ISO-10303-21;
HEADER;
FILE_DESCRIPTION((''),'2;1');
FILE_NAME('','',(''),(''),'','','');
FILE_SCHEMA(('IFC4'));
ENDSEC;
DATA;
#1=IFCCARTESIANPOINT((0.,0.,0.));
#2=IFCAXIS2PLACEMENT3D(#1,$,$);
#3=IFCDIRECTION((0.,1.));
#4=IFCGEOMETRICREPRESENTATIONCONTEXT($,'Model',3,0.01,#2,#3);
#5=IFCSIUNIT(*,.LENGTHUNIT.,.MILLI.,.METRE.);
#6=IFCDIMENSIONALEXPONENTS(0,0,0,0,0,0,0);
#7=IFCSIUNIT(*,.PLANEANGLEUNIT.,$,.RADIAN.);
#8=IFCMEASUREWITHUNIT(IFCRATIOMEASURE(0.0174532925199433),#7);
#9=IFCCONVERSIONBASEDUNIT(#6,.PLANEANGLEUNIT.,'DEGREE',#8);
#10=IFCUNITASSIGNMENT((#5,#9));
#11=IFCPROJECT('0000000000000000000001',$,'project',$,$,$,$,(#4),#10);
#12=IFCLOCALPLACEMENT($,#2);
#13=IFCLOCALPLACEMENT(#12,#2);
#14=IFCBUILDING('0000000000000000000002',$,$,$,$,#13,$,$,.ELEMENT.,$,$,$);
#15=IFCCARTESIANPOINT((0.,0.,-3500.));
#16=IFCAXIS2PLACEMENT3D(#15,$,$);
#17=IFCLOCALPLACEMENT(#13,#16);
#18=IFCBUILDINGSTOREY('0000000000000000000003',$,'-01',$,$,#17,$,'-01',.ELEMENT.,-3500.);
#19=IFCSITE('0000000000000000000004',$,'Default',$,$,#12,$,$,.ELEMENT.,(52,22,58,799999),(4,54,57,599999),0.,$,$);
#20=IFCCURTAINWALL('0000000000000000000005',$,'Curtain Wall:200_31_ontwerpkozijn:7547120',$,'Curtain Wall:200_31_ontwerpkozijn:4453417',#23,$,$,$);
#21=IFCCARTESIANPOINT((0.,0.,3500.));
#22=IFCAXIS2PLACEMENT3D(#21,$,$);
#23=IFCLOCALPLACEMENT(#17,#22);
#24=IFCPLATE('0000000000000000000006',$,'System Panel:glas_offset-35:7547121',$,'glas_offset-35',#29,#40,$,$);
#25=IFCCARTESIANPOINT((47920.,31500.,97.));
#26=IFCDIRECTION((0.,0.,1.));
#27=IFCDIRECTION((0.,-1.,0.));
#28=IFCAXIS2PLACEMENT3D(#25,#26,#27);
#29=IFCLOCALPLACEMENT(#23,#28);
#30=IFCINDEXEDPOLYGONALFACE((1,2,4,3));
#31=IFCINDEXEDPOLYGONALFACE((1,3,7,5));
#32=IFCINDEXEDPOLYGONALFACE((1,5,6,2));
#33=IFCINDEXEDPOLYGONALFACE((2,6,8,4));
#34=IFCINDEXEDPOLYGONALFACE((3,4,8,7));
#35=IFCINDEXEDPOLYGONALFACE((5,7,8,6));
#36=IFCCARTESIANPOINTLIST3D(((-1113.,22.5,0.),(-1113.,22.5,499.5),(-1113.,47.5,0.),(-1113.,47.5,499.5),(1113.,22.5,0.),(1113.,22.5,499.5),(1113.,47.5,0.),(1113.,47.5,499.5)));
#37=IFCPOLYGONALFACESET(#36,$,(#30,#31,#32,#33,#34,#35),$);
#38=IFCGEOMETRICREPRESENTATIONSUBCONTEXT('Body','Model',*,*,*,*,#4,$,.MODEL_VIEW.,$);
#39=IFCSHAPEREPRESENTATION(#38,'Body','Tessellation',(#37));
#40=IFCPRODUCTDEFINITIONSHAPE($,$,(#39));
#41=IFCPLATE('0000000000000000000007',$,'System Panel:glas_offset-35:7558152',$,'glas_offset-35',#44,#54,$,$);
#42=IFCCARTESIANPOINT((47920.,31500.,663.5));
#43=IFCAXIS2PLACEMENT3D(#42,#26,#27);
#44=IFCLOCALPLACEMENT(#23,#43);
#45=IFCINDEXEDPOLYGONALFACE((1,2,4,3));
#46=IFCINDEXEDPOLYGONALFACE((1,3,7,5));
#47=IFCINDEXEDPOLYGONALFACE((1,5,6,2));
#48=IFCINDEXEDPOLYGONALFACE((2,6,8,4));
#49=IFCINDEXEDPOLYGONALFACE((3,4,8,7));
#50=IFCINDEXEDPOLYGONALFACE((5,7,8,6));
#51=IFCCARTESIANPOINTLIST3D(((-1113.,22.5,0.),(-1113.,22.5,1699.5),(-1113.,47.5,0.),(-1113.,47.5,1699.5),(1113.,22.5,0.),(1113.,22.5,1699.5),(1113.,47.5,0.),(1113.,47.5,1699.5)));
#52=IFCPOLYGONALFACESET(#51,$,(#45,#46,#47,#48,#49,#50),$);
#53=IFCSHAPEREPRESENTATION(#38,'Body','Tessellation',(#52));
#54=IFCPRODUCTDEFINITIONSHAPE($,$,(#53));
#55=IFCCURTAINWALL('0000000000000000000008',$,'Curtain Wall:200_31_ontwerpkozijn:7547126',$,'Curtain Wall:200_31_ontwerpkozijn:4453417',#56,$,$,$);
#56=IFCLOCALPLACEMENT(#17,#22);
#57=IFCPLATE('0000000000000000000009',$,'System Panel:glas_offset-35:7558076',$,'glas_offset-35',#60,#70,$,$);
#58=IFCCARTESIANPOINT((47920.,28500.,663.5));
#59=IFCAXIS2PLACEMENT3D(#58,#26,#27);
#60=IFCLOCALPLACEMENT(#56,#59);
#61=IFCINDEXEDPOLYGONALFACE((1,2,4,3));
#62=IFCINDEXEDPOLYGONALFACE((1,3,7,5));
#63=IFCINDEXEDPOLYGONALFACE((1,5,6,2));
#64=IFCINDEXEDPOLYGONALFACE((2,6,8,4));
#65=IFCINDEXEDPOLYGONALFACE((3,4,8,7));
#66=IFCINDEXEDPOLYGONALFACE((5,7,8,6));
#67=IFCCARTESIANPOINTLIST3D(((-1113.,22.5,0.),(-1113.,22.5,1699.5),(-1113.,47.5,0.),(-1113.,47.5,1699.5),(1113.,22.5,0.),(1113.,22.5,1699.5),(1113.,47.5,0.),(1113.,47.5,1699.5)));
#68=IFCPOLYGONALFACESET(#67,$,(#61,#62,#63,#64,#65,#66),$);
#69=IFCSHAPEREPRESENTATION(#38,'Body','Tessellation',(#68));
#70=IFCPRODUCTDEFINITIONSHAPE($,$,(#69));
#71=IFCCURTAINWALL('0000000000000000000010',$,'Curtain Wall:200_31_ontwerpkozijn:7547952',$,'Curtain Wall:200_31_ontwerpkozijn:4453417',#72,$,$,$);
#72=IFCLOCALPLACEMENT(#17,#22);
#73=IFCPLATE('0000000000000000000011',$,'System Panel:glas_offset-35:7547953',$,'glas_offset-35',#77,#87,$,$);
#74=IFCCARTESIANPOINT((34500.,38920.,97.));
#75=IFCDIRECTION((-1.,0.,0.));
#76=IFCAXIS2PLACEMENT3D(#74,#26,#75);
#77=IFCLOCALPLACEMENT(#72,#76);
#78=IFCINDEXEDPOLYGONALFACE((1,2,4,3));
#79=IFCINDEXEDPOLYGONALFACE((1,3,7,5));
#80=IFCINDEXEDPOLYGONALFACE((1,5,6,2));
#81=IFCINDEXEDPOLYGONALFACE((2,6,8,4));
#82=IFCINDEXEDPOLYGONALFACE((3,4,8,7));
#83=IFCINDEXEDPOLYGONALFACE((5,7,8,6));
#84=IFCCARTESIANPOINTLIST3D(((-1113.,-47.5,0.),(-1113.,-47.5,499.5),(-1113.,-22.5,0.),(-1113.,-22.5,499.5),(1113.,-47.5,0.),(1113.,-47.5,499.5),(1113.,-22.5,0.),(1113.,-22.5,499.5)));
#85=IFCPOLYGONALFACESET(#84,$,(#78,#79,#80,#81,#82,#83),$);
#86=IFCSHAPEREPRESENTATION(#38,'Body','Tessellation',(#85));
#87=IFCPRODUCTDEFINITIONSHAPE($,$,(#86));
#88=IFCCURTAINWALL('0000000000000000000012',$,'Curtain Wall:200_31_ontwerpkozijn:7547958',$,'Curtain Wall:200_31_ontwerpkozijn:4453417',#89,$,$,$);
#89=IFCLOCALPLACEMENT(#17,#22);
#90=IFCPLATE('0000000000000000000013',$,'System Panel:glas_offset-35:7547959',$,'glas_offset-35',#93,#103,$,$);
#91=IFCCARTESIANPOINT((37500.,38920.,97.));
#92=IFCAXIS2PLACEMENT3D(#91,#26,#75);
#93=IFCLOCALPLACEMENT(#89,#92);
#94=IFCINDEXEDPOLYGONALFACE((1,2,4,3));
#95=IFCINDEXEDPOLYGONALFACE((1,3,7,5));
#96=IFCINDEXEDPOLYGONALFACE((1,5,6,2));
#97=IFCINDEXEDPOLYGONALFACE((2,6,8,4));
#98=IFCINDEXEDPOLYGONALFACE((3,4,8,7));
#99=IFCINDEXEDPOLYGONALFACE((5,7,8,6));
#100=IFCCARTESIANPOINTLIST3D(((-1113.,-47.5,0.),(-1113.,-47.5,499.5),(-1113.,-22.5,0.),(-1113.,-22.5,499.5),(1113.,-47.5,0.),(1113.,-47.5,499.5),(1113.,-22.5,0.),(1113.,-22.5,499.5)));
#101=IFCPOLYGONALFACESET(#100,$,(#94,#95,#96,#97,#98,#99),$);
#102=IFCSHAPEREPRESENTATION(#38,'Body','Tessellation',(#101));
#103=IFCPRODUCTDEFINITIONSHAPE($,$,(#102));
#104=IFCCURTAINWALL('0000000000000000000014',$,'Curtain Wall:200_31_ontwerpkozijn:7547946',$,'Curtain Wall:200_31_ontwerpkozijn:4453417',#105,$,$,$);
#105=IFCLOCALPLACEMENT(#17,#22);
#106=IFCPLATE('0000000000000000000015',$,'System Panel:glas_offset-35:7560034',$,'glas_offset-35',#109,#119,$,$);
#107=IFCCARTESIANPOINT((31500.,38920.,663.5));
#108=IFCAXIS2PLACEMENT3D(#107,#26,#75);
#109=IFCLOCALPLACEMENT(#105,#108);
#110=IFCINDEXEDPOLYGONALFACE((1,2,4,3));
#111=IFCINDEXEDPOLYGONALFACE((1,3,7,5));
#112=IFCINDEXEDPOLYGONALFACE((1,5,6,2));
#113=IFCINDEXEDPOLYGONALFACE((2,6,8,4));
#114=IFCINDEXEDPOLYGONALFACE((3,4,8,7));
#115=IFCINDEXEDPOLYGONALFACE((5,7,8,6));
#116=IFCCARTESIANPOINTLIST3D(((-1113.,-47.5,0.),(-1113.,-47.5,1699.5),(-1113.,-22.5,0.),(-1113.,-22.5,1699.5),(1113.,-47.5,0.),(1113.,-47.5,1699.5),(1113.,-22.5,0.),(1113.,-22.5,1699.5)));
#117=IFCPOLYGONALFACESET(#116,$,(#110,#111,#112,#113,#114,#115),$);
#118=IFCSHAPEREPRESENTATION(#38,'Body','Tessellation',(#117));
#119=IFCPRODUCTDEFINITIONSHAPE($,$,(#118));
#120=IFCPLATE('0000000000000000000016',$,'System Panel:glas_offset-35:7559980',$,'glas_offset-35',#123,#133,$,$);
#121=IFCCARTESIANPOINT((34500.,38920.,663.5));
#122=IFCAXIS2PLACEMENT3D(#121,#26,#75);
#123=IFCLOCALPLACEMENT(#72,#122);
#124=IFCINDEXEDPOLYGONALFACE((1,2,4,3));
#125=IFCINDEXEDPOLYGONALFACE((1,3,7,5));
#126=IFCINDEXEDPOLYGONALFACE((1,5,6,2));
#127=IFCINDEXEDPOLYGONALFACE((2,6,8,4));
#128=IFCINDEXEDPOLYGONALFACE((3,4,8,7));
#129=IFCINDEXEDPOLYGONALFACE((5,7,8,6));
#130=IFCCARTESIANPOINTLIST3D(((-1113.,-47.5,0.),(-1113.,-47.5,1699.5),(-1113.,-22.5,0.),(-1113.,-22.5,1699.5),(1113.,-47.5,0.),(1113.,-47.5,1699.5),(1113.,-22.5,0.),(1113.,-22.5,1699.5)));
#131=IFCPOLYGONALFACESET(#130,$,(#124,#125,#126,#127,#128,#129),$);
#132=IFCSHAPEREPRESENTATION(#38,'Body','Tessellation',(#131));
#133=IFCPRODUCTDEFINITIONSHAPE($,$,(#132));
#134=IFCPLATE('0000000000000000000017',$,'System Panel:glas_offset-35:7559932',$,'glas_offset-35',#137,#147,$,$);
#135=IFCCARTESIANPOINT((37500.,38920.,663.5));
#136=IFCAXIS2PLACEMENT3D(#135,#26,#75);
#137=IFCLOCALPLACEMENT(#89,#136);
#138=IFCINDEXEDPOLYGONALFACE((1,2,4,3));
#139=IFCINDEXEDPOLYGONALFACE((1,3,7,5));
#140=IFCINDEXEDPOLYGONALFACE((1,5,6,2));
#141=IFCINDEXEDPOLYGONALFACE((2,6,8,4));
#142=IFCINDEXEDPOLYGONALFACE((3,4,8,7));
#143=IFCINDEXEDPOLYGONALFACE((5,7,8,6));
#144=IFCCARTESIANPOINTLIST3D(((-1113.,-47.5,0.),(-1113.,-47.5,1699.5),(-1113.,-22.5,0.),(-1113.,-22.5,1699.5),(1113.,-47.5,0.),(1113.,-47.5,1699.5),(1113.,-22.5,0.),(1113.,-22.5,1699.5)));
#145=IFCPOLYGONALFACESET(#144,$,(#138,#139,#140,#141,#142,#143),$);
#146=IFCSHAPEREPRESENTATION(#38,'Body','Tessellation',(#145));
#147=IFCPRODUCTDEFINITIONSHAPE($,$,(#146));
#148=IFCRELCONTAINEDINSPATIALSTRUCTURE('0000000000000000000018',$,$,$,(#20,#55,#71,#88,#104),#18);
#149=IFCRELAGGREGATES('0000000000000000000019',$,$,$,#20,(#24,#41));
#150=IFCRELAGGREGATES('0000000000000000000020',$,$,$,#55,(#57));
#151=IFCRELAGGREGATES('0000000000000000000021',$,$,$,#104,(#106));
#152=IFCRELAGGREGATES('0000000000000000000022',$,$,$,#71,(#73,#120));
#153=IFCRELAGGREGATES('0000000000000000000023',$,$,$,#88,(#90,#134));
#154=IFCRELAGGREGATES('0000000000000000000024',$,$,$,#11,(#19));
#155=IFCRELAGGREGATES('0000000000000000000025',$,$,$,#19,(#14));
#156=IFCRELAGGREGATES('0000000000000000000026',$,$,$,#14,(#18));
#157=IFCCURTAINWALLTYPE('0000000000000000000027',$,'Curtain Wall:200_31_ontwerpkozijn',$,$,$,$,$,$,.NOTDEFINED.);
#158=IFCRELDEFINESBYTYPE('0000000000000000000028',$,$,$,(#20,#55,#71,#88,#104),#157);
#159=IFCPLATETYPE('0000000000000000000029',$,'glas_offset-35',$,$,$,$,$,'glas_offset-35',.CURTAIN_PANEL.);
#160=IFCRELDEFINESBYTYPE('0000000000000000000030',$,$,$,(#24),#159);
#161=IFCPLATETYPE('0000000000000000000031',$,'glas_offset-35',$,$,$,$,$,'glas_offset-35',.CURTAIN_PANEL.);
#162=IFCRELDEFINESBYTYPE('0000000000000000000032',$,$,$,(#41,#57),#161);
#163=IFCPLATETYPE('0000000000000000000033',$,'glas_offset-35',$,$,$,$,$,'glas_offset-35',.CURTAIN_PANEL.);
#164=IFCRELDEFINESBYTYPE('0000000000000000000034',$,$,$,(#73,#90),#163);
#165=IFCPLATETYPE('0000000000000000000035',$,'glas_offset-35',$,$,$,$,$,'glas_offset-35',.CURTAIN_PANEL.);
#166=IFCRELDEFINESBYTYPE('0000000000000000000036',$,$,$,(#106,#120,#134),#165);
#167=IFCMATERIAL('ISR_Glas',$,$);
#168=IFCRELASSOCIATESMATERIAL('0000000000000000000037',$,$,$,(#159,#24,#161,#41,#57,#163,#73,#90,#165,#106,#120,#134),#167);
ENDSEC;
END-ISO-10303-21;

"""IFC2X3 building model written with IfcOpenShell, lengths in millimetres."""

from ifc_helpers import new_model, entity, si_unit, converted_unit, direction, frame, frame_2d, origin, origin_2d_with_axis, place, context, subcontext, project, spatial, rectangle, extrude, source, transform, mapped, material, type_object, type_shapes, element, aggregate, save


model = new_model("IFC2X3")

# Units and contexts
model_context = context("Model", 3, precision=0.01, world=origin(), true_north=direction((0.0, 1.0)))
body_context = subcontext(model_context, "Body", "Model", "MODEL_VIEW")
ifc_project = project(units=[si_unit("LENGTHUNIT", "METRE", prefix="MILLI"), converted_unit("PLANEANGLEUNIT", "DEGREE", entity("IfcRatioMeasure", 0.0174532925199433), si_unit("PLANEANGLEUNIT", "RADIAN"), dimensions=[0, 0, 0, 0, 0, 0, 0])], contexts=[model_context])

# Site, building, storey
site_placement = place(None, origin())
site = spatial("IfcSite", under=ifc_project, at=site_placement, Name="Default", CompositionType="ELEMENT", RefLatitude=(52, 22, 58, 799999), RefLongitude=(4, 54, 57, 599999), RefElevation=0.0)
building_placement = place(site_placement, origin())
building = spatial("IfcBuilding", under=site, at=building_placement, CompositionType="ELEMENT")
storey_placement = place(building_placement, frame((0.0, 0.0, -3500.0)))
storey = spatial("IfcBuildingStorey", under=building, at=storey_placement, Name="-01", LongName="-01", CompositionType="ELEMENT", Elevation=-3500.0)

# Curtain wall, plates
curtain_wall_type = type_object("IfcCurtainWallType", Name="Curtain Wall:200_31_ontwerpkozijn", PredefinedType="NOTDEFINED")
curtain_wall_1_placement = place(storey_placement, frame((0.0, 0.0, 3500.0)))
curtain_wall_1 = element("IfcCurtainWall", 1, at=curtain_wall_1_placement, inside=storey, type_object=curtain_wall_type, Name="Curtain Wall:200_31_ontwerpkozijn:7547120", ObjectType="Curtain Wall:200_31_ontwerpkozijn:4453417")
ifc_material_1 = material(Name="ISR_Glas")
plate_type_1 = type_object("IfcPlateType", Name="glas_offset-35", ElementType="glas_offset-35", PredefinedType="CURTAIN_PANEL", material=ifc_material_1)
shared_shape_1 = source(origin(), body_context, "Body", "SweptSolid", [
    extrude(rectangle(XDim=25.0, YDim=2226.0, at=origin_2d_with_axis()), frame((0.0, 35.0, 0.0), z_axis=(0.0, 0.0, 1.0), x_axis=(0.0, 1.0, 0.0)), (0.0, 0.0, 1.0), 499.5),
])
type_shapes(plate_type_1, [shared_shape_1])
plate_1_placement = place(curtain_wall_1_placement, frame((47920.0, 31500.0, 97.0), z_axis=(0.0, 0.0, 1.0), x_axis=(0.0, -1.0, 0.0)))
plate_1 = element("IfcPlate", 2, at=plate_1_placement, type_object=plate_type_1, material=ifc_material_1, Name="System Panel:glas_offset-35:7547121", ObjectType="glas_offset-35", context=body_context, shape_type="MappedRepresentation", body=[
    mapped(shared_shape_1, transform((0.0, 0.0, 0.0), scale=1.0)),
])
plate_type_2 = type_object("IfcPlateType", Name="glas_offset-35", ElementType="glas_offset-35", PredefinedType="CURTAIN_PANEL", material=ifc_material_1)
shared_shape_2 = source(origin(), body_context, "Body", "SweptSolid", [
    extrude(rectangle(XDim=25.0, YDim=2226.0, at=origin_2d_with_axis()), frame((0.0, 35.0, 0.0), z_axis=(0.0, 0.0, 1.0), x_axis=(0.0, 1.0, 0.0)), (0.0, 0.0, 1.0), 1699.5),
])
type_shapes(plate_type_2, [shared_shape_2])
plate_2_placement = place(curtain_wall_1_placement, frame((47920.0, 31500.0, 663.5), z_axis=(0.0, 0.0, 1.0), x_axis=(0.0, -1.0, 0.0)))
plate_2 = element("IfcPlate", 3, at=plate_2_placement, type_object=plate_type_2, material=ifc_material_1, Name="System Panel:glas_offset-35:7558152", ObjectType="glas_offset-35", context=body_context, shape_type="MappedRepresentation", body=[
    mapped(shared_shape_2, transform((0.0, 0.0, 0.0), scale=1.0)),
])
aggregate(curtain_wall_1, [plate_1, plate_2])

# Curtain walls, plates
curtain_wall_2_placement = place(storey_placement, frame((0.0, 0.0, 3500.0)))
curtain_wall_2 = element("IfcCurtainWall", 4, at=curtain_wall_2_placement, inside=storey, type_object=curtain_wall_type, Name="Curtain Wall:200_31_ontwerpkozijn:7547126", ObjectType="Curtain Wall:200_31_ontwerpkozijn:4453417")
plate_3_placement = place(curtain_wall_2_placement, frame((47920.0, 28500.0, 663.5), z_axis=(0.0, 0.0, 1.0), x_axis=(0.0, -1.0, 0.0)))
plate_3 = element("IfcPlate", 5, at=plate_3_placement, type_object=plate_type_2, material=ifc_material_1, Name="System Panel:glas_offset-35:7558076", ObjectType="glas_offset-35", context=body_context, shape_type="MappedRepresentation", body=[
    mapped(shared_shape_2, transform((0.0, 0.0, 0.0), scale=1.0)),
])
aggregate(curtain_wall_2, [plate_3])
curtain_wall_3_placement = place(storey_placement, frame((0.0, 0.0, 3500.0)))
curtain_wall_3 = element("IfcCurtainWall", 6, at=curtain_wall_3_placement, inside=storey, type_object=curtain_wall_type, Name="Curtain Wall:200_31_ontwerpkozijn:7547952", ObjectType="Curtain Wall:200_31_ontwerpkozijn:4453417")
plate_type_3 = type_object("IfcPlateType", Name="glas_offset-35", ElementType="glas_offset-35", PredefinedType="CURTAIN_PANEL", material=ifc_material_1)
shared_shape_3 = source(origin(), body_context, "Body", "SweptSolid", [
    extrude(rectangle(XDim=25.0, YDim=2226.0, at=frame_2d((0.0, 0.0), x_axis=(1.0, 0.0))), frame((0.0, -35.0, 0.0), z_axis=(0.0, 0.0, 1.0), x_axis=(0.0, 1.0, 0.0)), (0.0, 0.0, 1.0), 499.5),
])
type_shapes(plate_type_3, [shared_shape_3])
plate_4_placement = place(curtain_wall_3_placement, frame((34500.0, 38920.0, 97.0), z_axis=(0.0, 0.0, 1.0), x_axis=(-1.0, 0.0, 0.0)))
plate_4 = element("IfcPlate", 7, at=plate_4_placement, type_object=plate_type_3, material=ifc_material_1, Name="System Panel:glas_offset-35:7547953", ObjectType="glas_offset-35", context=body_context, shape_type="MappedRepresentation", body=[
    mapped(shared_shape_3, transform((0.0, 0.0, 0.0), scale=1.0)),
])
curtain_wall_4_placement = place(storey_placement, frame((0.0, 0.0, 3500.0)))
curtain_wall_4 = element("IfcCurtainWall", 8, at=curtain_wall_4_placement, inside=storey, type_object=curtain_wall_type, Name="Curtain Wall:200_31_ontwerpkozijn:7547958", ObjectType="Curtain Wall:200_31_ontwerpkozijn:4453417")
plate_5_placement = place(curtain_wall_4_placement, frame((37500.0, 38920.0, 97.0), z_axis=(0.0, 0.0, 1.0), x_axis=(-1.0, 0.0, 0.0)))
plate_5 = element("IfcPlate", 9, at=plate_5_placement, type_object=plate_type_3, material=ifc_material_1, Name="System Panel:glas_offset-35:7547959", ObjectType="glas_offset-35", context=body_context, shape_type="MappedRepresentation", body=[
    mapped(shared_shape_3, transform((0.0, 0.0, 0.0), scale=1.0)),
])
curtain_wall_5_placement = place(storey_placement, frame((0.0, 0.0, 3500.0)))
curtain_wall_5 = element("IfcCurtainWall", 10, at=curtain_wall_5_placement, inside=storey, type_object=curtain_wall_type, Name="Curtain Wall:200_31_ontwerpkozijn:7547946", ObjectType="Curtain Wall:200_31_ontwerpkozijn:4453417")
plate_type_4 = type_object("IfcPlateType", Name="glas_offset-35", ElementType="glas_offset-35", PredefinedType="CURTAIN_PANEL", material=ifc_material_1)
shared_shape_4 = source(origin(), body_context, "Body", "SweptSolid", [
    extrude(rectangle(XDim=25.0, YDim=2226.0, at=frame_2d((0.0, 0.0), x_axis=(1.0, 0.0))), frame((0.0, -35.0, 0.0), z_axis=(0.0, 0.0, 1.0), x_axis=(0.0, 1.0, 0.0)), (0.0, 0.0, 1.0), 1699.5),
])
type_shapes(plate_type_4, [shared_shape_4])
plate_6_placement = place(curtain_wall_5_placement, frame((31500.0, 38920.0, 663.5), z_axis=(0.0, 0.0, 1.0), x_axis=(-1.0, 0.0, 0.0)))
plate_6 = element("IfcPlate", 11, at=plate_6_placement, type_object=plate_type_4, material=ifc_material_1, Name="System Panel:glas_offset-35:7560034", ObjectType="glas_offset-35", context=body_context, shape_type="MappedRepresentation", body=[
    mapped(shared_shape_4, transform((0.0, 0.0, 0.0), scale=1.0)),
])
aggregate(curtain_wall_5, [plate_6])

# Plates
plate_7_placement = place(curtain_wall_3_placement, frame((34500.0, 38920.0, 663.5), z_axis=(0.0, 0.0, 1.0), x_axis=(-1.0, 0.0, 0.0)))
plate_7 = element("IfcPlate", 12, at=plate_7_placement, type_object=plate_type_4, material=ifc_material_1, Name="System Panel:glas_offset-35:7559980", ObjectType="glas_offset-35", context=body_context, shape_type="MappedRepresentation", body=[
    mapped(shared_shape_4, transform((0.0, 0.0, 0.0), scale=1.0)),
])
aggregate(curtain_wall_3, [plate_4, plate_7])
plate_8_placement = place(curtain_wall_4_placement, frame((37500.0, 38920.0, 663.5), z_axis=(0.0, 0.0, 1.0), x_axis=(-1.0, 0.0, 0.0)))
plate_8 = element("IfcPlate", 13, at=plate_8_placement, type_object=plate_type_4, material=ifc_material_1, Name="System Panel:glas_offset-35:7559932", ObjectType="glas_offset-35", context=body_context, shape_type="MappedRepresentation", body=[
    mapped(shared_shape_4, transform((0.0, 0.0, 0.0), scale=1.0)),
])
aggregate(curtain_wall_4, [plate_5, plate_8])

save(model, "model.ifc")
